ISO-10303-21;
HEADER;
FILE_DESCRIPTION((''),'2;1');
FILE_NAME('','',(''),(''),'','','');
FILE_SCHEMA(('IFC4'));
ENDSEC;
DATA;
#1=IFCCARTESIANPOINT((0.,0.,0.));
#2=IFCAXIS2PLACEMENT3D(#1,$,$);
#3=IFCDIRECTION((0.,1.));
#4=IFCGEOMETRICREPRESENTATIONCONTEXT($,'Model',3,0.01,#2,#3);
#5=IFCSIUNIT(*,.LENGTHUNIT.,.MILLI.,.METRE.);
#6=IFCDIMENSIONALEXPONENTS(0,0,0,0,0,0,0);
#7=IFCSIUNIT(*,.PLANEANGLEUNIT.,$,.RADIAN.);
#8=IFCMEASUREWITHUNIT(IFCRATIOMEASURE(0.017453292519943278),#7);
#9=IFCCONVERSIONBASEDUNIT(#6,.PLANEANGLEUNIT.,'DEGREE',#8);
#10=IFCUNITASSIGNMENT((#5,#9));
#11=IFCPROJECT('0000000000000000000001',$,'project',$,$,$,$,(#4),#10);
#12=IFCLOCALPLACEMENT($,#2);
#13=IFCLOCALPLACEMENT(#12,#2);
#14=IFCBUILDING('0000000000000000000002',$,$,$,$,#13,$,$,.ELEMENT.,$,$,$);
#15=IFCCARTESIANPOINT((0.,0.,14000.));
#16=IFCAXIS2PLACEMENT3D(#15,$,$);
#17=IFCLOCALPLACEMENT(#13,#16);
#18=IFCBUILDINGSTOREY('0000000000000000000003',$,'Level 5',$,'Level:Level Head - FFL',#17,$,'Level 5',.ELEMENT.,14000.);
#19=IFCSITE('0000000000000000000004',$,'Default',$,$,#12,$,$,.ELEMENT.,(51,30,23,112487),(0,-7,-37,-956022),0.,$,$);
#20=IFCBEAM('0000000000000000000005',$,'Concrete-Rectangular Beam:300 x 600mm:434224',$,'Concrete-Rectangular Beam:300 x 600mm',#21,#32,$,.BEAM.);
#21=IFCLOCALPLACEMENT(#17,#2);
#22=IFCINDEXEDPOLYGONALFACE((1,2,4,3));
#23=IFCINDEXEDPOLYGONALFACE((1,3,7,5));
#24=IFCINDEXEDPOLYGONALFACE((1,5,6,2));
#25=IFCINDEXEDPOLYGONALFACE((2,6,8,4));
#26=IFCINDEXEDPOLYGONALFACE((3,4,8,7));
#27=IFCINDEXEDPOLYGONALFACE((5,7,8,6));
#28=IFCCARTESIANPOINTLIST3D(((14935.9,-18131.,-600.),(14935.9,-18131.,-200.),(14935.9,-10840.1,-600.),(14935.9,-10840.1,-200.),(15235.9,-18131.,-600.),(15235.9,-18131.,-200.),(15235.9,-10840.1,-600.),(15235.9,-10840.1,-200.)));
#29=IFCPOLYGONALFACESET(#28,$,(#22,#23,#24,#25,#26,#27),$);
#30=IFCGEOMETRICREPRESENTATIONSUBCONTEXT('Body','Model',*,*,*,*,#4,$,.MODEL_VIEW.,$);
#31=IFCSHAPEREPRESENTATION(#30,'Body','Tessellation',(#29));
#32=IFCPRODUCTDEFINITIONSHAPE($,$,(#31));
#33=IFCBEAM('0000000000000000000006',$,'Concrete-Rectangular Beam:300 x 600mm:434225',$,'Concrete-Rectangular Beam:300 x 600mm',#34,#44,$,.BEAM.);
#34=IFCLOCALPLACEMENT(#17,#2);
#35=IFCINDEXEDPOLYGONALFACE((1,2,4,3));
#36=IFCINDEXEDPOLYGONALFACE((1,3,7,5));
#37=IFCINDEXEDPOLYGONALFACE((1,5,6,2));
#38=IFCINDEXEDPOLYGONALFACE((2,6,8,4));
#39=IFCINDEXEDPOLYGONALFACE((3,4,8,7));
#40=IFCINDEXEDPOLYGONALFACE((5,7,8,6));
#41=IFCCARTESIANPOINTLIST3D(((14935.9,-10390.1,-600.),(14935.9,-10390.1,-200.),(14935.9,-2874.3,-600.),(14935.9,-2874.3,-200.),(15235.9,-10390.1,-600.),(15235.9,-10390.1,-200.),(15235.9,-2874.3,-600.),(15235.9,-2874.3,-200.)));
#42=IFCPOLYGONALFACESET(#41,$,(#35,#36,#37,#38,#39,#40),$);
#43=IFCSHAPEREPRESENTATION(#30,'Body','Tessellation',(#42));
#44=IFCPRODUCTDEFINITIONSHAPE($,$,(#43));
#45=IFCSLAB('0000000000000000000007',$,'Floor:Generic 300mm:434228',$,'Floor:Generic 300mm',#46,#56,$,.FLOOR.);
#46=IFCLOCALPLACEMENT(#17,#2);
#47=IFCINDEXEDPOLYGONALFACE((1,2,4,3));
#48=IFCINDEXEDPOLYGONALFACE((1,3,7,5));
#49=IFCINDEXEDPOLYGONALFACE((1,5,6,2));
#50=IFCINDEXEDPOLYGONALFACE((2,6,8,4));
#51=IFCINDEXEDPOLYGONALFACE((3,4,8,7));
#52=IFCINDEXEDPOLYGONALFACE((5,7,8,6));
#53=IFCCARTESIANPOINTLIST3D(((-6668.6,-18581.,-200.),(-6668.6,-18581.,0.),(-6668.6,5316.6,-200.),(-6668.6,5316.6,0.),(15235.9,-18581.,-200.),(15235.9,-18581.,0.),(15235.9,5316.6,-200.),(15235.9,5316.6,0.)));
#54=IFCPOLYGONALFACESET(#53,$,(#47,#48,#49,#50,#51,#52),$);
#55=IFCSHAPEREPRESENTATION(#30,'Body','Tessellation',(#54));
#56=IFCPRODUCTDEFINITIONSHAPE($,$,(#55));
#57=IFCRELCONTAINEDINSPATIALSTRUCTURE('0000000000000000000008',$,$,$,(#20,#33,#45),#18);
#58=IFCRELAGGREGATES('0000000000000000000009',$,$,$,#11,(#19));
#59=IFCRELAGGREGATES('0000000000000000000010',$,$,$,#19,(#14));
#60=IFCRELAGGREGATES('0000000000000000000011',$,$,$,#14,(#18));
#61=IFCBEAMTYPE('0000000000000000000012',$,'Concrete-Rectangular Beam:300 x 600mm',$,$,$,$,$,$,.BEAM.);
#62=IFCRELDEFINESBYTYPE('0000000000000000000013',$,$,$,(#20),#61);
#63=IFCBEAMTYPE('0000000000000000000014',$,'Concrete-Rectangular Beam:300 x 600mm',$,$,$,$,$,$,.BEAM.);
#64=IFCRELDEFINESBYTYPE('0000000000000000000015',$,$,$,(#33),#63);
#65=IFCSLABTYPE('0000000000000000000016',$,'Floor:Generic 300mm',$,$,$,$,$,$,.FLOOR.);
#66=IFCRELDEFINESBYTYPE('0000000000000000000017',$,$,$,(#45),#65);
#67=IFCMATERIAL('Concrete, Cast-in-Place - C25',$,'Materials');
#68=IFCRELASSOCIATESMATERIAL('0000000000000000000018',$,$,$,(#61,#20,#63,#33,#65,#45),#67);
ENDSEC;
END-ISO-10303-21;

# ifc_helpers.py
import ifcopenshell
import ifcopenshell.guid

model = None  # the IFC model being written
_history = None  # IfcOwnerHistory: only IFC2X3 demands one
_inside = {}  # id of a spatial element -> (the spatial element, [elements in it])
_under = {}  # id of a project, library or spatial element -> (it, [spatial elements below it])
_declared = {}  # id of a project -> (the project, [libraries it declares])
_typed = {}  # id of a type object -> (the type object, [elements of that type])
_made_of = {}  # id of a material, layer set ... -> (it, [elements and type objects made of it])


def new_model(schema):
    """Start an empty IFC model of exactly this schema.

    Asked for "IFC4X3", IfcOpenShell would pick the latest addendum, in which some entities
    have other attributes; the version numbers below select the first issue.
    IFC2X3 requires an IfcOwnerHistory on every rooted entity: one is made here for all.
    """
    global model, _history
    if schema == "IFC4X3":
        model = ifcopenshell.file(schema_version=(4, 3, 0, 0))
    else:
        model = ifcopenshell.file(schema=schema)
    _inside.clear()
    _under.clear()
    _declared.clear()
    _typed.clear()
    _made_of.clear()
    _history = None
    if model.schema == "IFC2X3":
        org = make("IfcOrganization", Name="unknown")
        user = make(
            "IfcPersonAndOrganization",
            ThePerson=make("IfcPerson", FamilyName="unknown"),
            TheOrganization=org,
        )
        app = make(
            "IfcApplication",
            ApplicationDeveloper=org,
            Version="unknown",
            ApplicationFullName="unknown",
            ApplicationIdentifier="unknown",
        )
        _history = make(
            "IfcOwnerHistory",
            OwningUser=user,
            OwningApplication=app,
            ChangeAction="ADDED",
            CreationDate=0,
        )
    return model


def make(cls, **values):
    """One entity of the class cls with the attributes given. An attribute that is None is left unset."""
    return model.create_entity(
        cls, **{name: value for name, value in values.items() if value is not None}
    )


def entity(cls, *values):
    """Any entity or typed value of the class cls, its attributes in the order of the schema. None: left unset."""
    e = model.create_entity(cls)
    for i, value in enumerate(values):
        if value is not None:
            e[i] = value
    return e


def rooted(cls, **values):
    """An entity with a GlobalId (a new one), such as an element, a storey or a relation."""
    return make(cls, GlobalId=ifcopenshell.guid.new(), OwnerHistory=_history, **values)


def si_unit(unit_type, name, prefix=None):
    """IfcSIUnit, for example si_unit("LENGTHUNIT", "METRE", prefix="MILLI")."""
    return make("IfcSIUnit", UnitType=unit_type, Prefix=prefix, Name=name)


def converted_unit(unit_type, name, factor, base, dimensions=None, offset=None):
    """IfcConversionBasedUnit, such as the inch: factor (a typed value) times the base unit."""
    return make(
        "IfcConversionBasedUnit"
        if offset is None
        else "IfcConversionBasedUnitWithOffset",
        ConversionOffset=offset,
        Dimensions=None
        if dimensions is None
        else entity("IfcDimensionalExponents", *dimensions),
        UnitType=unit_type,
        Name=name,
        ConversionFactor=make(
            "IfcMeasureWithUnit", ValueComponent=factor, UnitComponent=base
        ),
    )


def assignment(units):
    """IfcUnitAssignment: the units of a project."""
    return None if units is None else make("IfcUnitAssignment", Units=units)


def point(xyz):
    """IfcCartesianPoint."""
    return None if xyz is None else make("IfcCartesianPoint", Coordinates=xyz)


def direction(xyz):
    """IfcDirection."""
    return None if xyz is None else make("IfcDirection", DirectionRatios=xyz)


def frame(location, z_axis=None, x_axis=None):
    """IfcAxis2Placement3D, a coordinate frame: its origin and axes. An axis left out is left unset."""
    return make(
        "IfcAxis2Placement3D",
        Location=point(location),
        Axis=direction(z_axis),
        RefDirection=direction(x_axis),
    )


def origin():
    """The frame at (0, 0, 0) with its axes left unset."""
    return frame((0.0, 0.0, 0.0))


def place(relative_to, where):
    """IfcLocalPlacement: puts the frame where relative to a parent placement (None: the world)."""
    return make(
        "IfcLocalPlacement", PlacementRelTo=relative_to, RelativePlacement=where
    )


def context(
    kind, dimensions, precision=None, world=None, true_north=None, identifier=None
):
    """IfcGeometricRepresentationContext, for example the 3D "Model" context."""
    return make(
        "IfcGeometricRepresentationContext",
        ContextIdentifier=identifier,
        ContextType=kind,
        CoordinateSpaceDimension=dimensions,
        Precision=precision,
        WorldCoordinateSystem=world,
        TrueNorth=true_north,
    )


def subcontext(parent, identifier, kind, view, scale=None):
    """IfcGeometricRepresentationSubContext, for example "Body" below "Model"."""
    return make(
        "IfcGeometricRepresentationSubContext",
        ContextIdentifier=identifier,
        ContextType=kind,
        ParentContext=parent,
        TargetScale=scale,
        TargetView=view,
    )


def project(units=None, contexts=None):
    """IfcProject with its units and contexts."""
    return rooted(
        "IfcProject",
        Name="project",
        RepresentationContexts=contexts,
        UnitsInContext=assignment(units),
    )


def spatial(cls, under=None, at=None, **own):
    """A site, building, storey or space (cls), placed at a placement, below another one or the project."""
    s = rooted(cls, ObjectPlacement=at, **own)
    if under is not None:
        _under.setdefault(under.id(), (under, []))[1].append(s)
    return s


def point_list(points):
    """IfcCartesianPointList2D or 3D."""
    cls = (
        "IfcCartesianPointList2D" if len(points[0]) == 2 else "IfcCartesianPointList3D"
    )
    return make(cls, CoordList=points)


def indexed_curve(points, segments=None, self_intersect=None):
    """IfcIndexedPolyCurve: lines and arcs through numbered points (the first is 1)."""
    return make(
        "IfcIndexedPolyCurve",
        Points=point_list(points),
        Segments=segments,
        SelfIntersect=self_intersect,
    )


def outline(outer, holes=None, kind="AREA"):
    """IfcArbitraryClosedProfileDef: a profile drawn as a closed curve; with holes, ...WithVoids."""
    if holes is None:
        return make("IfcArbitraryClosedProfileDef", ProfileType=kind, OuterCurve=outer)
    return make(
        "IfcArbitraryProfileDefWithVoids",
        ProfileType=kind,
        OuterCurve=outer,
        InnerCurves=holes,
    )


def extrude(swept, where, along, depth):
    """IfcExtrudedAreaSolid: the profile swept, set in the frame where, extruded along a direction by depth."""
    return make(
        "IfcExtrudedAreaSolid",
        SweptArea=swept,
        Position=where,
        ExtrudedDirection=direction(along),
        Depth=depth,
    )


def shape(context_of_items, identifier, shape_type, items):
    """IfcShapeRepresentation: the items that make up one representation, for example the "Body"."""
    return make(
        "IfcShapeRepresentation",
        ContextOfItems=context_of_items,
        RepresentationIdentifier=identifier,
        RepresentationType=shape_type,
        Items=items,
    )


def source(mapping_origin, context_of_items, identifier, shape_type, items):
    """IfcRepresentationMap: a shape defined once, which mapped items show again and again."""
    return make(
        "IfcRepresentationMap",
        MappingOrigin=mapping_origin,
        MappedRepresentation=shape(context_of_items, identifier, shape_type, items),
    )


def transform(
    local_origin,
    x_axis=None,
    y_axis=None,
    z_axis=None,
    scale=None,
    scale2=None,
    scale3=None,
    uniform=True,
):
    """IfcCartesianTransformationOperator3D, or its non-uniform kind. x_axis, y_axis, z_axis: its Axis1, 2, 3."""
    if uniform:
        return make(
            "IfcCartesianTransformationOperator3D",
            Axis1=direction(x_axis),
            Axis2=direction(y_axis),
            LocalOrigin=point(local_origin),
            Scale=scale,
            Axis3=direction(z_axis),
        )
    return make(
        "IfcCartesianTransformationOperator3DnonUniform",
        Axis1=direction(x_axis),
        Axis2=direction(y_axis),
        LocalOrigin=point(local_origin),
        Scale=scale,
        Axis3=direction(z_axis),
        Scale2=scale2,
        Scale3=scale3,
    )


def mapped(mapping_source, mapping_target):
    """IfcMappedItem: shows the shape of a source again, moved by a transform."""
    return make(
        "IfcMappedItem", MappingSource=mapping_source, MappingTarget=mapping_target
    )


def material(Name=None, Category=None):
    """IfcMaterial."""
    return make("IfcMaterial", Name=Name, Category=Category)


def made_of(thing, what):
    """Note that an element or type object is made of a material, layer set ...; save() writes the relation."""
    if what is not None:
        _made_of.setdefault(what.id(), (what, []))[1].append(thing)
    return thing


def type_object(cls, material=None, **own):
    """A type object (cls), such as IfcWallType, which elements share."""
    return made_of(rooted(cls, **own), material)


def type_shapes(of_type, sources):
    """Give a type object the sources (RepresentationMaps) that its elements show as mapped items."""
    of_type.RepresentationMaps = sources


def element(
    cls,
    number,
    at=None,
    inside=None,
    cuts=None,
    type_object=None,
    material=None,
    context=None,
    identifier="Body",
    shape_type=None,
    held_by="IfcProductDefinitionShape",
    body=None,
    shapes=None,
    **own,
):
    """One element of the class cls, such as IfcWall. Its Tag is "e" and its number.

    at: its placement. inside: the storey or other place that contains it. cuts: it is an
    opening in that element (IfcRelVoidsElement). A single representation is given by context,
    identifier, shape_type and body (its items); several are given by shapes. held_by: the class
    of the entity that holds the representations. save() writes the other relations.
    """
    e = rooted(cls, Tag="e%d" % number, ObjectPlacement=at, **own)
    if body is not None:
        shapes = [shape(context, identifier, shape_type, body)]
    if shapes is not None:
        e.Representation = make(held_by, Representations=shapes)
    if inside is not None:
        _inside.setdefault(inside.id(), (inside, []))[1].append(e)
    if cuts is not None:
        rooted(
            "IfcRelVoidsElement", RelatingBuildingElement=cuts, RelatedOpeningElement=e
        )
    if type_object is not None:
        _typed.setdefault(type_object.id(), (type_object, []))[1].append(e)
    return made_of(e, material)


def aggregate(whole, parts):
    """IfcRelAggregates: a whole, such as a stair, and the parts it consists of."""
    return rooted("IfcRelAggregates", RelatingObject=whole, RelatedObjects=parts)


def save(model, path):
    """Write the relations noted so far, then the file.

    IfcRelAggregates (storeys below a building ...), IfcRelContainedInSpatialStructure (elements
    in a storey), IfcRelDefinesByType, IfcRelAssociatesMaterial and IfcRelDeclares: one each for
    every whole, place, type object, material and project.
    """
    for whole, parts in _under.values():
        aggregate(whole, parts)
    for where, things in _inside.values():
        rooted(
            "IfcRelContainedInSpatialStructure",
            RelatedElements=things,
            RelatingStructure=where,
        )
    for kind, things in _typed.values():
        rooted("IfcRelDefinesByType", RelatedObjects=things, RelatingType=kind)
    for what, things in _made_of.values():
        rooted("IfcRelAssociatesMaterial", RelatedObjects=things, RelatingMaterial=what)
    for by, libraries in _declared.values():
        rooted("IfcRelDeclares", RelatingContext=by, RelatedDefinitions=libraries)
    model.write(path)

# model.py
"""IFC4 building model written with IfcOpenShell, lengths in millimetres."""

from ifc_helpers import new_model, entity, si_unit, converted_unit, direction, frame, origin, place, context, subcontext, project, spatial, indexed_curve, outline, extrude, source, transform, mapped, material, type_object, type_shapes, element, save


model = new_model("IFC4")

# Units and contexts
model_context = context("Model", 3, precision=0.01, world=origin(), true_north=direction((0.0, 1.0)))
body_context = subcontext(model_context, "Body", "Model", "MODEL_VIEW")
ifc_project = project(units=[si_unit("LENGTHUNIT", "METRE", prefix="MILLI"), converted_unit("PLANEANGLEUNIT", "DEGREE", entity("IfcRatioMeasure", 0.017453292519943278), si_unit("PLANEANGLEUNIT", "RADIAN"), dimensions=[0, 0, 0, 0, 0, 0, 0])], contexts=[model_context])

# Site, building, storey
site_placement = place(None, origin())
site = spatial("IfcSite", under=ifc_project, at=site_placement, Name="Default", CompositionType="ELEMENT", RefLatitude=(51, 30, 23, 112487), RefLongitude=(0, -7, -37, -956022), RefElevation=0.0)
building_placement = place(site_placement, origin())
building = spatial("IfcBuilding", under=site, at=building_placement, CompositionType="ELEMENT")
storey_placement = place(building_placement, frame((0.0, 0.0, 14000.0)))
storey = spatial("IfcBuildingStorey", under=building, at=storey_placement, Name="Level 5", ObjectType="Level:Level Head - FFL", LongName="Level 5", CompositionType="ELEMENT", Elevation=14000.0)

# Beams
ifc_material = material(Name="Concrete, Cast-in-Place - C25", Category="Materials")
beam_type_1 = type_object("IfcBeamType", Name="Concrete-Rectangular Beam:300 x 600mm", PredefinedType="BEAM", material=ifc_material)
shared_shape_1 = source(origin(), body_context, "Body", "SweptSolid", [
    extrude(outline(indexed_curve([(-150.0, -200.0), (150.0, -200.0), (150.0, 200.0), (-150.0, 200.0), (-150.0, -200.0)], self_intersect=False)), frame((15085.9, -18131.0, 13600.0), z_axis=(0.0, 1.0, 0.0), x_axis=(-1.0, 0.0, 0.0)), (0.0, 0.0, 1.0), 7290.9),
])
type_shapes(beam_type_1, [shared_shape_1])
beam_1_placement = place(storey_placement, frame((0.0, 0.0, -14000.0)))
element("IfcBeam", 1, at=beam_1_placement, inside=storey, type_object=beam_type_1, material=ifc_material, Name="Concrete-Rectangular Beam:300 x 600mm:434224", ObjectType="Concrete-Rectangular Beam:300 x 600mm", PredefinedType="BEAM", context=body_context, shape_type="MappedRepresentation", body=[
    mapped(shared_shape_1, transform((0.0, 0.0, 0.0), scale=1.0)),
])
beam_type_2 = type_object("IfcBeamType", Name="Concrete-Rectangular Beam:300 x 600mm", PredefinedType="BEAM", material=ifc_material)
shared_shape_2 = source(origin(), body_context, "Body", "SweptSolid", [
    extrude(outline(indexed_curve([(-150.0, -200.0), (150.0, -200.0), (150.0, 200.0), (-150.0, 200.0), (-150.0, -200.0)], self_intersect=False)), frame((15085.9, -10390.1, 13600.0), z_axis=(0.0, 1.0, 0.0), x_axis=(-1.0, 0.0, 0.0)), (0.0, 0.0, 1.0), 7515.9),
])
type_shapes(beam_type_2, [shared_shape_2])
beam_2_placement = place(storey_placement, frame((0.0, 0.0, -14000.0)))
element("IfcBeam", 2, at=beam_2_placement, inside=storey, type_object=beam_type_2, material=ifc_material, Name="Concrete-Rectangular Beam:300 x 600mm:434225", ObjectType="Concrete-Rectangular Beam:300 x 600mm", PredefinedType="BEAM", context=body_context, shape_type="MappedRepresentation", body=[
    mapped(shared_shape_2, transform((0.0, 0.0, 0.0), scale=1.0)),
])

# Slab
slab_type = type_object("IfcSlabType", Name="Floor:Generic 300mm", PredefinedType="FLOOR", material=ifc_material)
slab_placement = place(storey_placement, origin())
element("IfcSlab", 3, at=slab_placement, inside=storey, type_object=slab_type, material=ifc_material, Name="Floor:Generic 300mm:434228", ObjectType="Floor:Generic 300mm", PredefinedType="FLOOR", context=body_context, shape_type="SweptSolid", body=[
    extrude(outline(indexed_curve([(-11948.8, -10952.2), (11948.8, -10952.2), (11948.8, 10952.2), (-11948.8, 10952.2), (-11948.8, -10952.2)], self_intersect=False)), frame((4283.6, -6632.2, 0.0), z_axis=(0.0, 0.0, -1.0), x_axis=(0.0, 1.0, 0.0)), (0.0, 0.0, 1.0), 200.0),
])

save(model, "model.ifc")
